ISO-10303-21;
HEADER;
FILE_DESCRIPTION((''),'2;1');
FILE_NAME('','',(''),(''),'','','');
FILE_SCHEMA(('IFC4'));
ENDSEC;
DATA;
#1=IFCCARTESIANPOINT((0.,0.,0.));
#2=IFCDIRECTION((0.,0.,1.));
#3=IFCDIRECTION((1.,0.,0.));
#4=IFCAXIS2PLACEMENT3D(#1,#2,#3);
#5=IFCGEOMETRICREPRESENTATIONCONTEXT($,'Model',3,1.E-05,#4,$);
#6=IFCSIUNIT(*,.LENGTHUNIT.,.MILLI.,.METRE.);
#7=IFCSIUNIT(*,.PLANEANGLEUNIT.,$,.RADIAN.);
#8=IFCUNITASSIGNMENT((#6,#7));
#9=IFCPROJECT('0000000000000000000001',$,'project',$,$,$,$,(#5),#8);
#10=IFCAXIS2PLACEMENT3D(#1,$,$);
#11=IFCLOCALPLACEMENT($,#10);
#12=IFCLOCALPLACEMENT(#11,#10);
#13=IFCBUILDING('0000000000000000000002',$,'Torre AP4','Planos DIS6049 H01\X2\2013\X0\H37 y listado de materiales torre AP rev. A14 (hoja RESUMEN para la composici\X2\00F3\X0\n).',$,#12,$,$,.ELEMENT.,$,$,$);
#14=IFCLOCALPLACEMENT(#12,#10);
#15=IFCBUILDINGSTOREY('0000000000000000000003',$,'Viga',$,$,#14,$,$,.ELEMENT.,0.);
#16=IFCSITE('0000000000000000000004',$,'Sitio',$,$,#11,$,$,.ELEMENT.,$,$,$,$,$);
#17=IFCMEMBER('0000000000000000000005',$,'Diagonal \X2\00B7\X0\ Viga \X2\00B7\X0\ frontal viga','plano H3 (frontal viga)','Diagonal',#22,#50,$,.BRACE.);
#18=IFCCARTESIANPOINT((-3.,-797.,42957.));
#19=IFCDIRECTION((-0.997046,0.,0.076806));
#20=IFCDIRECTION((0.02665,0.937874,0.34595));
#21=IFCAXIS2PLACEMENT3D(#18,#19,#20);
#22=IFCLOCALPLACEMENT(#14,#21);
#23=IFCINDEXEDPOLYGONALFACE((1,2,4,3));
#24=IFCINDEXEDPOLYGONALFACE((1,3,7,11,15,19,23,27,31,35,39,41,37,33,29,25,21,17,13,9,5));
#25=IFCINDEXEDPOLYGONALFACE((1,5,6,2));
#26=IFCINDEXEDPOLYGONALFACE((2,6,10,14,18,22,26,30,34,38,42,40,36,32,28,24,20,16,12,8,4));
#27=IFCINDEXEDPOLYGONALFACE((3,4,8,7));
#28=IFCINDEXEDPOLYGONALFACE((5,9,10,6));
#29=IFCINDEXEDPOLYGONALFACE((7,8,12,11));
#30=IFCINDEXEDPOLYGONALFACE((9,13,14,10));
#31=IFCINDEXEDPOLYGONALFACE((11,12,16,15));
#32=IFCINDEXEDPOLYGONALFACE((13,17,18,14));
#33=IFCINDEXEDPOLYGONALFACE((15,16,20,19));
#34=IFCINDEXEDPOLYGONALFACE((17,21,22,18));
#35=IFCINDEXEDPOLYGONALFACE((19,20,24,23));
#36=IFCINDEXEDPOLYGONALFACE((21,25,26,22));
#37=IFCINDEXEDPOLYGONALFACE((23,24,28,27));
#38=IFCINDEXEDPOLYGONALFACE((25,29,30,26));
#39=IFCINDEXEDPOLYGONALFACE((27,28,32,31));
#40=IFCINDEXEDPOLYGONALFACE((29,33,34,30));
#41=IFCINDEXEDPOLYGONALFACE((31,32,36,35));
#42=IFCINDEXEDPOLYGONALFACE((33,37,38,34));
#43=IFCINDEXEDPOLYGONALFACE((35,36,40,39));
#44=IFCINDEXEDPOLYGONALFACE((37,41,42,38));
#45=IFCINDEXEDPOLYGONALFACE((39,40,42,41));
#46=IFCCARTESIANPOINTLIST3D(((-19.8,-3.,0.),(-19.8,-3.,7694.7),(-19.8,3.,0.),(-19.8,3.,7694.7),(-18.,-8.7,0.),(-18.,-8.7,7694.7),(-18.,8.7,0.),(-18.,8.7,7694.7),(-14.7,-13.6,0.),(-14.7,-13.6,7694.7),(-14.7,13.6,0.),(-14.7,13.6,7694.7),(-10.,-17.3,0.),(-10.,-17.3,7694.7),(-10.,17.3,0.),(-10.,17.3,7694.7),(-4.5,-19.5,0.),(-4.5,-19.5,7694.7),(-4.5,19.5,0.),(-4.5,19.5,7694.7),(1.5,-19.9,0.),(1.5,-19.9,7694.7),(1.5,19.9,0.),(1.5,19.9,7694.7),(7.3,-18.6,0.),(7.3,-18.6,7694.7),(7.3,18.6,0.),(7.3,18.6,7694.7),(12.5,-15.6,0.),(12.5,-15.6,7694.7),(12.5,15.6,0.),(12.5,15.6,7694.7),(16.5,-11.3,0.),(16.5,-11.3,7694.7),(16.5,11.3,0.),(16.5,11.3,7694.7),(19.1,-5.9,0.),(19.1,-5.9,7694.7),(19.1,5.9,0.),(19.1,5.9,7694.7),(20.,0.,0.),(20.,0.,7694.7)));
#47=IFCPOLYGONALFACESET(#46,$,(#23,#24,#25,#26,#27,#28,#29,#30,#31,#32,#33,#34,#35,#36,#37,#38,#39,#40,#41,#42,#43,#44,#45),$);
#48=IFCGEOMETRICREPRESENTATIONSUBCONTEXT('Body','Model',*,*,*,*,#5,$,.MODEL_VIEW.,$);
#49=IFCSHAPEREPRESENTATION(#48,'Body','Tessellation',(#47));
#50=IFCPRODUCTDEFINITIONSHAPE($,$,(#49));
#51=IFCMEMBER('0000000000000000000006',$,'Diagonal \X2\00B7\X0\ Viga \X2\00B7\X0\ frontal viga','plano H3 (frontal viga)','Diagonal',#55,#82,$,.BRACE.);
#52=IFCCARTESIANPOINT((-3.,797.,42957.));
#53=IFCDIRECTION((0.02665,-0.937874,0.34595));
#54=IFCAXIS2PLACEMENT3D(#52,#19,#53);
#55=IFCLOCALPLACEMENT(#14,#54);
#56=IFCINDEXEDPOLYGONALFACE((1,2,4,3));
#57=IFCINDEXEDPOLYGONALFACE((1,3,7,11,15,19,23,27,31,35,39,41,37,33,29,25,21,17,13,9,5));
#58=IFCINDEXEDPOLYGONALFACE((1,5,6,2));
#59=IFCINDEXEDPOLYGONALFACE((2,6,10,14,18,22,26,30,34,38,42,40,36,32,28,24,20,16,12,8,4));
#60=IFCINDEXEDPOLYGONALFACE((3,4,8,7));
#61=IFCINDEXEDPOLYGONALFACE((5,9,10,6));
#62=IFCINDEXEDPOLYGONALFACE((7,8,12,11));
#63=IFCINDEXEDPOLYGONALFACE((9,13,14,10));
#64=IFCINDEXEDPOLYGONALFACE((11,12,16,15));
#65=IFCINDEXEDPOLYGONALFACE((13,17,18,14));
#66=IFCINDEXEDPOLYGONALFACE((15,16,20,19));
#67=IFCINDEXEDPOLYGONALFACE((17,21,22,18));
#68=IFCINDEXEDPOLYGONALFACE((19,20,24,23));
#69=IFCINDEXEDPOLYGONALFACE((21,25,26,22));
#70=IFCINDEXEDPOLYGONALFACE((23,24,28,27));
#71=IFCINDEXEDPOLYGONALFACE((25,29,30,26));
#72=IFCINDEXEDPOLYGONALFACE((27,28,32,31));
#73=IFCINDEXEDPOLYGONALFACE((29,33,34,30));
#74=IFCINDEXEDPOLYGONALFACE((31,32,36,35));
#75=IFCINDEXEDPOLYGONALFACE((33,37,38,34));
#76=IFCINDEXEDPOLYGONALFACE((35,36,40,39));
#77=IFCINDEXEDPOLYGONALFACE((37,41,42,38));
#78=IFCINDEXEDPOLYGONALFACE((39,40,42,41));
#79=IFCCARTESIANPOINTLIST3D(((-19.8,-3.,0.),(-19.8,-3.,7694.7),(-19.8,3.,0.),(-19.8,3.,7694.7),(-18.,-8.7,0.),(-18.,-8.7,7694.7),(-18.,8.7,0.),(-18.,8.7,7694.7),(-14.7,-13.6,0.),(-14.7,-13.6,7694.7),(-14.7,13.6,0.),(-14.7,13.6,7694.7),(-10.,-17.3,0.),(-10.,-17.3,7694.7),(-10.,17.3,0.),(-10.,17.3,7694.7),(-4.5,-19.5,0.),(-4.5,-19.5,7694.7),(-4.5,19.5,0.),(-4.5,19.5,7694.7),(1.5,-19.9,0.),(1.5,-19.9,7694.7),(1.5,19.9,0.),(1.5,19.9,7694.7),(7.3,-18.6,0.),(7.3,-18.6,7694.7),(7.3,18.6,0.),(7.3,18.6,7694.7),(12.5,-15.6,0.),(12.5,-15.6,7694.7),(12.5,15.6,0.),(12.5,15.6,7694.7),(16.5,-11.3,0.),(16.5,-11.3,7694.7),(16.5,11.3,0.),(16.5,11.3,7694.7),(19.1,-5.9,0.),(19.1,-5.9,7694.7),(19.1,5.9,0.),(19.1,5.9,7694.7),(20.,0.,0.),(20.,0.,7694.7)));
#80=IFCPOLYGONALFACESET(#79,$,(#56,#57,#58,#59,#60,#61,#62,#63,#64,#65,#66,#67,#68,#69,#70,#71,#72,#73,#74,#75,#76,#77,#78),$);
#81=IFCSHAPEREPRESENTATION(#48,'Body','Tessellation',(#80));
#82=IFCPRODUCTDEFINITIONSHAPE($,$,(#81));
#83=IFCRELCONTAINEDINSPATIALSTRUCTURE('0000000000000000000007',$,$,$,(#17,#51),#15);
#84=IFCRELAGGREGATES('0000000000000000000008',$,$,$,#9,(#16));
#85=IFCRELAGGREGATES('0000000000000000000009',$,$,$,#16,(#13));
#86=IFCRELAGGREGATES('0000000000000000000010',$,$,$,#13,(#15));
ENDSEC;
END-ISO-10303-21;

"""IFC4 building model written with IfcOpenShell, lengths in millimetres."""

from ifc_helpers import new_model, si_unit, frame, origin, origin_with_axes, place, context, subcontext, project, spatial, circle, extrude, element, save


model = new_model("IFC4")

# Units and contexts
model_context = context("Model", 3, precision=1e-05, world=origin_with_axes())
body_context = subcontext(model_context, "Body", "Model", "MODEL_VIEW")
ifc_project = project(units=[si_unit("LENGTHUNIT", "METRE", prefix="MILLI"), si_unit("PLANEANGLEUNIT", "RADIAN")], contexts=[model_context])

# Site, building, storey
site_placement = place(None, origin())
site = spatial("IfcSite", under=ifc_project, at=site_placement, Name="Sitio", CompositionType="ELEMENT")
building_placement = place(site_placement, origin())
building = spatial("IfcBuilding", under=site, at=building_placement, Name="Torre AP4", Description="Planos DIS6049 H01–H37 y listado de materiales torre AP rev. A14 (hoja RESUMEN para la composición).", CompositionType="ELEMENT")
storey_placement = place(building_placement, origin())
storey = spatial("IfcBuildingStorey", under=building, at=storey_placement, Name="Viga", CompositionType="ELEMENT", Elevation=0.0)

# Members
for number, where, z_axis, x_axis, name in (
    (1, (-3.0, -797.0, 42957.0), (-0.997046, 0.0, 0.076806), (0.02665, 0.937874, 0.34595), "Diagonal · Viga · frontal viga"),
    (2, (-3.0, 797.0, 42957.0), (-0.997046, 0.0, 0.076806), (0.02665, -0.937874, 0.34595), "Diagonal · Viga · frontal viga"),
):
    element("IfcMember", number, at=place(storey_placement, frame(where, z_axis=z_axis, x_axis=x_axis)), inside=storey, Name=name, Description="plano H3 (frontal viga)", ObjectType="Diagonal", PredefinedType="BRACE", context=body_context, shape_type="SweptSolid", body=[
        extrude(circle(Radius=20.0), None, (0.0, 0.0, 1.0), 7694.7),
    ])

save(model, "model.ifc")
